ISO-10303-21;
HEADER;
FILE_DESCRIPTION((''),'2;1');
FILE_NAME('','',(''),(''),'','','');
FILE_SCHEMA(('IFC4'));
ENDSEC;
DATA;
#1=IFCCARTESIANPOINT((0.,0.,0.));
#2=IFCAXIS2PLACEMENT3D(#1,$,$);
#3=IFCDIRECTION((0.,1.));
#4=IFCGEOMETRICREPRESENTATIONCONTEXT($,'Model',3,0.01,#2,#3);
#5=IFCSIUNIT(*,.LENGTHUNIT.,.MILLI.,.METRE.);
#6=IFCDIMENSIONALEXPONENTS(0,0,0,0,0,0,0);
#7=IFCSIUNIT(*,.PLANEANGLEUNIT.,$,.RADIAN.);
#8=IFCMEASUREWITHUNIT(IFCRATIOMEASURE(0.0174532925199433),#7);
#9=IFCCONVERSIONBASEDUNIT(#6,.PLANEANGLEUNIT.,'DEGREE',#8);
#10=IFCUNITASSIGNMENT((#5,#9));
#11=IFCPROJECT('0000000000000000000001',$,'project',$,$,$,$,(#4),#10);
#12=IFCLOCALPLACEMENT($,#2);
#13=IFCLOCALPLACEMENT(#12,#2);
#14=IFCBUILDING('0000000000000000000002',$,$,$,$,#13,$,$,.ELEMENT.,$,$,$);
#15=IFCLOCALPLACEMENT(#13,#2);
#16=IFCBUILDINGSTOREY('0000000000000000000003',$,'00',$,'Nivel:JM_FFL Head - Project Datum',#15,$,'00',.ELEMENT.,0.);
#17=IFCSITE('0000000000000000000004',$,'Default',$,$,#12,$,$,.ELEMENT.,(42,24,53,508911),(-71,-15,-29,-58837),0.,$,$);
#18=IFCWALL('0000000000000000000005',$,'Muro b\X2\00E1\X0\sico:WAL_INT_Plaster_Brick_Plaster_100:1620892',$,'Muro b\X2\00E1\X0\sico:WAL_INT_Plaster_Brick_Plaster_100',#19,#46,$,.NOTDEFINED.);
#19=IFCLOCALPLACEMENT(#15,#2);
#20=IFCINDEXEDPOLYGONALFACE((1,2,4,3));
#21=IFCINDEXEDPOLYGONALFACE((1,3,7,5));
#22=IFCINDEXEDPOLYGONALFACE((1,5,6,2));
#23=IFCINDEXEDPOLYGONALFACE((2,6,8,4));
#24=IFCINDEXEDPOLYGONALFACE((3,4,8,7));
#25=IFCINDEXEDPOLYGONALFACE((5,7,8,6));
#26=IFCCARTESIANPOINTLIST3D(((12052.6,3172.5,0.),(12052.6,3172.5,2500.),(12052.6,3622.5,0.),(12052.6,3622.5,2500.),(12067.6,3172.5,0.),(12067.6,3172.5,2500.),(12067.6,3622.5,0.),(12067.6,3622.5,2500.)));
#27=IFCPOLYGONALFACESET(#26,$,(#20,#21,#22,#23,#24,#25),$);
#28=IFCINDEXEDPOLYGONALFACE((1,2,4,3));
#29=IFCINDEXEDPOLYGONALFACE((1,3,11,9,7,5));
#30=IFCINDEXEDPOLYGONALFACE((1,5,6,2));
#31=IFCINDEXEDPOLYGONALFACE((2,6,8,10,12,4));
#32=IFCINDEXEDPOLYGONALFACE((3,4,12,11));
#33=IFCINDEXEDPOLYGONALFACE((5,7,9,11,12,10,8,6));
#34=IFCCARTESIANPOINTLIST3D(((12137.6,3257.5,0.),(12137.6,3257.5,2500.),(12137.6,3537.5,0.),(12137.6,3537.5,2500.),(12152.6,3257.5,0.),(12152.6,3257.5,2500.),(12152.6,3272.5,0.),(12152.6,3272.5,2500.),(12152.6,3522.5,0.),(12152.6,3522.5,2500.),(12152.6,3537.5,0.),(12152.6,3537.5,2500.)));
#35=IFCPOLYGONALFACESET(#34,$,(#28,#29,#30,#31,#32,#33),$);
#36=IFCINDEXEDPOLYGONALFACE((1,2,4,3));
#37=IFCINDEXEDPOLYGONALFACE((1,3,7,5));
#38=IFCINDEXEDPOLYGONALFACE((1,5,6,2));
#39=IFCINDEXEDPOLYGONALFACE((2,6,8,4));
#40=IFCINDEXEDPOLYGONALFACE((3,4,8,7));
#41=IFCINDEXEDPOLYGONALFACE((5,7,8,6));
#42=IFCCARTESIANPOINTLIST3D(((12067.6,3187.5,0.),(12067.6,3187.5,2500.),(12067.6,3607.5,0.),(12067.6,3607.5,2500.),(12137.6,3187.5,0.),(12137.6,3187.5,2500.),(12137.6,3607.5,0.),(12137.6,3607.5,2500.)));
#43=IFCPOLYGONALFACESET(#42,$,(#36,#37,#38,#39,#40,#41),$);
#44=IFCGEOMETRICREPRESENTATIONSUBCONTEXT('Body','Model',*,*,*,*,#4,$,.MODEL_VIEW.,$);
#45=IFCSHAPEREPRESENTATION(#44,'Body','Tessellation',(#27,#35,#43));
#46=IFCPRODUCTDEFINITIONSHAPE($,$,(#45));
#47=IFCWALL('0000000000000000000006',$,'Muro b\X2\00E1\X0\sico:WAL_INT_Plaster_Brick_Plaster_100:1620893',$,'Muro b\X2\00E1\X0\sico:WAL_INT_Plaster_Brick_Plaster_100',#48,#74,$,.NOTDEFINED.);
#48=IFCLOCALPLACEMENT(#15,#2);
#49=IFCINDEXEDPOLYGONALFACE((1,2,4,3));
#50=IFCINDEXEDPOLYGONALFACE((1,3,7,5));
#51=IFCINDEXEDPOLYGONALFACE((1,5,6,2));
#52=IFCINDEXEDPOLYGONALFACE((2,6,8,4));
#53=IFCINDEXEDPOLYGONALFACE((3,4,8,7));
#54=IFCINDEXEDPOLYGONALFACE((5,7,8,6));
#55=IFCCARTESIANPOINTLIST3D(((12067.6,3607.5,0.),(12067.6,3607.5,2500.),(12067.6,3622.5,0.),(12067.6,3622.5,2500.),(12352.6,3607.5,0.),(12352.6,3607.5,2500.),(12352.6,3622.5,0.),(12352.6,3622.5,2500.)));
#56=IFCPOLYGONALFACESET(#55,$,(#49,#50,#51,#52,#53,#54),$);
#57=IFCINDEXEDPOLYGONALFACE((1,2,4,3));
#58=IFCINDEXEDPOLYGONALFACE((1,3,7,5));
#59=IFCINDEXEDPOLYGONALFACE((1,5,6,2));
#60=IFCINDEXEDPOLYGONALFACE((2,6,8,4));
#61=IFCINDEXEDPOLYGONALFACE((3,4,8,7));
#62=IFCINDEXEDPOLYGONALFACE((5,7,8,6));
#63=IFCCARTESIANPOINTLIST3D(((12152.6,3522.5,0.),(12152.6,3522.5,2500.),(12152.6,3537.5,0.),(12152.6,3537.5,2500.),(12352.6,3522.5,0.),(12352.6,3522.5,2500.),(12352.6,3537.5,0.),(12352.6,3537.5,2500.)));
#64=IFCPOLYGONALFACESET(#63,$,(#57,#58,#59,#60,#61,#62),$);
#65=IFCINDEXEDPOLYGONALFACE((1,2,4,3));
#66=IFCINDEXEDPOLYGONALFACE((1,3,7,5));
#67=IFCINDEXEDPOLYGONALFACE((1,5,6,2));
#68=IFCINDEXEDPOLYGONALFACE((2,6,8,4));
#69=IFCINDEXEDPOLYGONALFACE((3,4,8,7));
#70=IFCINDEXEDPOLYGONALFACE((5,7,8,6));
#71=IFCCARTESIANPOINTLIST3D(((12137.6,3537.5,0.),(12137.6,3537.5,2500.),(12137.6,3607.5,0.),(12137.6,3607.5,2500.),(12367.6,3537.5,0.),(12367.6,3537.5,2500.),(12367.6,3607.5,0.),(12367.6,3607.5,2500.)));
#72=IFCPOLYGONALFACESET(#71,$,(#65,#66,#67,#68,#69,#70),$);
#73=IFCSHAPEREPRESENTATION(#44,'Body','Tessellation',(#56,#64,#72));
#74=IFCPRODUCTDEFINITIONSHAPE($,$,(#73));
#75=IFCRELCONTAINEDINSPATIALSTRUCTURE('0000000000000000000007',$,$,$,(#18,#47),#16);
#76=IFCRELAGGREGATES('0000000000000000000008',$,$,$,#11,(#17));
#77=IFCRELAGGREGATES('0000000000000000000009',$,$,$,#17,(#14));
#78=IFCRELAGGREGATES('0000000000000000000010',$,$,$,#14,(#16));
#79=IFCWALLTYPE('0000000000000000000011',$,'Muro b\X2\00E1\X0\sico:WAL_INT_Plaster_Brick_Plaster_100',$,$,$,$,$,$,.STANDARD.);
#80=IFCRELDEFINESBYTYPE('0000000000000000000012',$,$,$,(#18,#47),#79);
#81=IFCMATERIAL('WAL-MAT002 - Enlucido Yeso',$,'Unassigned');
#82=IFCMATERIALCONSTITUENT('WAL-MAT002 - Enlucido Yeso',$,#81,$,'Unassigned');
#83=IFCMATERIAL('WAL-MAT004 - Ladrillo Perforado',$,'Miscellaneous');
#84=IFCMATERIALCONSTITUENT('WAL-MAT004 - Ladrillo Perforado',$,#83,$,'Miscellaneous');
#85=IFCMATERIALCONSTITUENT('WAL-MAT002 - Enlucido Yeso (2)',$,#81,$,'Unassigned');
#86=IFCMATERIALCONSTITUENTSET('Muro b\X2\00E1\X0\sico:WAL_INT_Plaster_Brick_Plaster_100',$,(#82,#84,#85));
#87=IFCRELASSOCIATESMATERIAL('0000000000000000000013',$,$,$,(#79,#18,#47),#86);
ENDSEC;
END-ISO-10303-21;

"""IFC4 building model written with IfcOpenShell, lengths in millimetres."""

from ifc_helpers import new_model, entity, si_unit, converted_unit, direction, frame, origin, place, context, subcontext, project, spatial, indexed_curve, outline, extrude, material, constituent, constituent_set, type_object, element, save


model = new_model("IFC4")

# Units and contexts
model_context = context("Model", 3, precision=0.01, world=origin(), true_north=direction((0.0, 1.0)))
body_context = subcontext(model_context, "Body", "Model", "MODEL_VIEW")
ifc_project = project(units=[si_unit("LENGTHUNIT", "METRE", prefix="MILLI"), converted_unit("PLANEANGLEUNIT", "DEGREE", entity("IfcRatioMeasure", 0.0174532925199433), si_unit("PLANEANGLEUNIT", "RADIAN"), dimensions=[0, 0, 0, 0, 0, 0, 0])], contexts=[model_context])

# Site, building, storey
site_placement = place(None, origin())
site = spatial("IfcSite", under=ifc_project, at=site_placement, Name="Default", CompositionType="ELEMENT", RefLatitude=(42, 24, 53, 508911), RefLongitude=(-71, -15, -29, -58837), RefElevation=0.0)
building_placement = place(site_placement, origin())
building = spatial("IfcBuilding", under=site, at=building_placement, CompositionType="ELEMENT")
storey_placement = place(building_placement, origin())
storey = spatial("IfcBuildingStorey", under=building, at=storey_placement, Name="00", ObjectType="Nivel:JM_FFL Head - Project Datum", LongName="00", CompositionType="ELEMENT", Elevation=0.0)

# Walls
ifc_material_1 = material(Name="WAL-MAT004 - Ladrillo Perforado", Category="Miscellaneous")
ifc_material_2 = material(Name="WAL-MAT002 - Enlucido Yeso", Category="Unassigned")
ifc_constituent_1 = constituent(ifc_material_2, Name="WAL-MAT002 - Enlucido Yeso", Category="Unassigned")
ifc_constituent_2 = constituent(ifc_material_1, Name="WAL-MAT004 - Ladrillo Perforado", Category="Miscellaneous")
ifc_constituent_3 = constituent(ifc_material_2, Name="WAL-MAT002 - Enlucido Yeso (2)", Category="Unassigned")
ifc_constituent_set_1 = constituent_set(constituents=[ifc_constituent_1, ifc_constituent_2, ifc_constituent_3], Name="Muro básico:WAL_INT_Plaster_Brick_Plaster_100")
wall_type_1 = type_object("IfcWallType", Name="Muro básico:WAL_INT_Plaster_Brick_Plaster_100", PredefinedType="STANDARD", material=ifc_constituent_set_1)
wall_1_placement = place(storey_placement, frame((12102.6, 3622.5, 0.0), z_axis=(0.0, 0.0, 1.0), x_axis=(0.0, -1.0, 0.0)))
element("IfcWall", 1, at=wall_1_placement, inside=storey, type_object=wall_type_1, material=ifc_constituent_set_1, Name="Muro básico:WAL_INT_Plaster_Brick_Plaster_100:1620892", ObjectType="Muro básico:WAL_INT_Plaster_Brick_Plaster_100", PredefinedType="NOTDEFINED", context=body_context, shape_type="SweptSolid", body=[
    extrude(outline(indexed_curve([(-7.5, -225.0), (7.5, -225.0), (7.5, 225.0), (-7.5, 225.0), (-7.5, -225.0)], self_intersect=False)), frame((225.0, -42.5, 0.0), z_axis=(0.0, 0.0, 1.0), x_axis=(0.0, 1.0, 0.0)), (0.0, 0.0, 1.0), 2500.0),
    extrude(outline(indexed_curve([(-125.0, -5.0), (125.0, -5.0), (140.0, -5.0), (140.0, 10.0), (-140.0, 10.0), (-140.0, -5.0), (-125.0, -5.0)], self_intersect=False)), frame((225.0, 45.0, 0.0), z_axis=(0.0, 0.0, 1.0), x_axis=(-1.0, 0.0, 0.0)), (0.0, 0.0, 1.0), 2500.0),
    extrude(outline(indexed_curve([(-210.0, -35.0), (210.0, -35.0), (210.0, 35.0), (-210.0, 35.0), (-210.0, -35.0)], self_intersect=False)), frame((225.0, 0.0, 0.0)), (0.0, 0.0, 1.0), 2500.0),
])
wall_2_placement = place(storey_placement, frame((12152.6, 3572.5, 0.0)))
element("IfcWall", 2, at=wall_2_placement, inside=storey, type_object=wall_type_1, material=ifc_constituent_set_1, Name="Muro básico:WAL_INT_Plaster_Brick_Plaster_100:1620893", ObjectType="Muro básico:WAL_INT_Plaster_Brick_Plaster_100", PredefinedType="NOTDEFINED", context=body_context, shape_type="SweptSolid", body=[
    extrude(outline(indexed_curve([(-7.5, -142.5), (7.5, -142.5), (7.5, 142.5), (-7.5, 142.5), (-7.5, -142.5)], self_intersect=False)), frame((57.5, 42.5, 0.0), z_axis=(0.0, 0.0, 1.0), x_axis=(0.0, -1.0, 0.0)), (0.0, 0.0, 1.0), 2500.0),
    extrude(outline(indexed_curve([(-7.5, -100.0), (7.5, -100.0), (7.5, 100.0), (-7.5, 100.0), (-7.5, -100.0)], self_intersect=False)), frame((100.0, -42.5, 0.0), z_axis=(0.0, 0.0, 1.0), x_axis=(0.0, 1.0, 0.0)), (0.0, 0.0, 1.0), 2500.0),
    extrude(outline(indexed_curve([(-115.0, -35.0), (115.0, -35.0), (115.0, 35.0), (-115.0, 35.0), (-115.0, -35.0)], self_intersect=False)), frame((100.0, 0.0, 0.0)), (0.0, 0.0, 1.0), 2500.0),
])

save(model, "model.ifc")
